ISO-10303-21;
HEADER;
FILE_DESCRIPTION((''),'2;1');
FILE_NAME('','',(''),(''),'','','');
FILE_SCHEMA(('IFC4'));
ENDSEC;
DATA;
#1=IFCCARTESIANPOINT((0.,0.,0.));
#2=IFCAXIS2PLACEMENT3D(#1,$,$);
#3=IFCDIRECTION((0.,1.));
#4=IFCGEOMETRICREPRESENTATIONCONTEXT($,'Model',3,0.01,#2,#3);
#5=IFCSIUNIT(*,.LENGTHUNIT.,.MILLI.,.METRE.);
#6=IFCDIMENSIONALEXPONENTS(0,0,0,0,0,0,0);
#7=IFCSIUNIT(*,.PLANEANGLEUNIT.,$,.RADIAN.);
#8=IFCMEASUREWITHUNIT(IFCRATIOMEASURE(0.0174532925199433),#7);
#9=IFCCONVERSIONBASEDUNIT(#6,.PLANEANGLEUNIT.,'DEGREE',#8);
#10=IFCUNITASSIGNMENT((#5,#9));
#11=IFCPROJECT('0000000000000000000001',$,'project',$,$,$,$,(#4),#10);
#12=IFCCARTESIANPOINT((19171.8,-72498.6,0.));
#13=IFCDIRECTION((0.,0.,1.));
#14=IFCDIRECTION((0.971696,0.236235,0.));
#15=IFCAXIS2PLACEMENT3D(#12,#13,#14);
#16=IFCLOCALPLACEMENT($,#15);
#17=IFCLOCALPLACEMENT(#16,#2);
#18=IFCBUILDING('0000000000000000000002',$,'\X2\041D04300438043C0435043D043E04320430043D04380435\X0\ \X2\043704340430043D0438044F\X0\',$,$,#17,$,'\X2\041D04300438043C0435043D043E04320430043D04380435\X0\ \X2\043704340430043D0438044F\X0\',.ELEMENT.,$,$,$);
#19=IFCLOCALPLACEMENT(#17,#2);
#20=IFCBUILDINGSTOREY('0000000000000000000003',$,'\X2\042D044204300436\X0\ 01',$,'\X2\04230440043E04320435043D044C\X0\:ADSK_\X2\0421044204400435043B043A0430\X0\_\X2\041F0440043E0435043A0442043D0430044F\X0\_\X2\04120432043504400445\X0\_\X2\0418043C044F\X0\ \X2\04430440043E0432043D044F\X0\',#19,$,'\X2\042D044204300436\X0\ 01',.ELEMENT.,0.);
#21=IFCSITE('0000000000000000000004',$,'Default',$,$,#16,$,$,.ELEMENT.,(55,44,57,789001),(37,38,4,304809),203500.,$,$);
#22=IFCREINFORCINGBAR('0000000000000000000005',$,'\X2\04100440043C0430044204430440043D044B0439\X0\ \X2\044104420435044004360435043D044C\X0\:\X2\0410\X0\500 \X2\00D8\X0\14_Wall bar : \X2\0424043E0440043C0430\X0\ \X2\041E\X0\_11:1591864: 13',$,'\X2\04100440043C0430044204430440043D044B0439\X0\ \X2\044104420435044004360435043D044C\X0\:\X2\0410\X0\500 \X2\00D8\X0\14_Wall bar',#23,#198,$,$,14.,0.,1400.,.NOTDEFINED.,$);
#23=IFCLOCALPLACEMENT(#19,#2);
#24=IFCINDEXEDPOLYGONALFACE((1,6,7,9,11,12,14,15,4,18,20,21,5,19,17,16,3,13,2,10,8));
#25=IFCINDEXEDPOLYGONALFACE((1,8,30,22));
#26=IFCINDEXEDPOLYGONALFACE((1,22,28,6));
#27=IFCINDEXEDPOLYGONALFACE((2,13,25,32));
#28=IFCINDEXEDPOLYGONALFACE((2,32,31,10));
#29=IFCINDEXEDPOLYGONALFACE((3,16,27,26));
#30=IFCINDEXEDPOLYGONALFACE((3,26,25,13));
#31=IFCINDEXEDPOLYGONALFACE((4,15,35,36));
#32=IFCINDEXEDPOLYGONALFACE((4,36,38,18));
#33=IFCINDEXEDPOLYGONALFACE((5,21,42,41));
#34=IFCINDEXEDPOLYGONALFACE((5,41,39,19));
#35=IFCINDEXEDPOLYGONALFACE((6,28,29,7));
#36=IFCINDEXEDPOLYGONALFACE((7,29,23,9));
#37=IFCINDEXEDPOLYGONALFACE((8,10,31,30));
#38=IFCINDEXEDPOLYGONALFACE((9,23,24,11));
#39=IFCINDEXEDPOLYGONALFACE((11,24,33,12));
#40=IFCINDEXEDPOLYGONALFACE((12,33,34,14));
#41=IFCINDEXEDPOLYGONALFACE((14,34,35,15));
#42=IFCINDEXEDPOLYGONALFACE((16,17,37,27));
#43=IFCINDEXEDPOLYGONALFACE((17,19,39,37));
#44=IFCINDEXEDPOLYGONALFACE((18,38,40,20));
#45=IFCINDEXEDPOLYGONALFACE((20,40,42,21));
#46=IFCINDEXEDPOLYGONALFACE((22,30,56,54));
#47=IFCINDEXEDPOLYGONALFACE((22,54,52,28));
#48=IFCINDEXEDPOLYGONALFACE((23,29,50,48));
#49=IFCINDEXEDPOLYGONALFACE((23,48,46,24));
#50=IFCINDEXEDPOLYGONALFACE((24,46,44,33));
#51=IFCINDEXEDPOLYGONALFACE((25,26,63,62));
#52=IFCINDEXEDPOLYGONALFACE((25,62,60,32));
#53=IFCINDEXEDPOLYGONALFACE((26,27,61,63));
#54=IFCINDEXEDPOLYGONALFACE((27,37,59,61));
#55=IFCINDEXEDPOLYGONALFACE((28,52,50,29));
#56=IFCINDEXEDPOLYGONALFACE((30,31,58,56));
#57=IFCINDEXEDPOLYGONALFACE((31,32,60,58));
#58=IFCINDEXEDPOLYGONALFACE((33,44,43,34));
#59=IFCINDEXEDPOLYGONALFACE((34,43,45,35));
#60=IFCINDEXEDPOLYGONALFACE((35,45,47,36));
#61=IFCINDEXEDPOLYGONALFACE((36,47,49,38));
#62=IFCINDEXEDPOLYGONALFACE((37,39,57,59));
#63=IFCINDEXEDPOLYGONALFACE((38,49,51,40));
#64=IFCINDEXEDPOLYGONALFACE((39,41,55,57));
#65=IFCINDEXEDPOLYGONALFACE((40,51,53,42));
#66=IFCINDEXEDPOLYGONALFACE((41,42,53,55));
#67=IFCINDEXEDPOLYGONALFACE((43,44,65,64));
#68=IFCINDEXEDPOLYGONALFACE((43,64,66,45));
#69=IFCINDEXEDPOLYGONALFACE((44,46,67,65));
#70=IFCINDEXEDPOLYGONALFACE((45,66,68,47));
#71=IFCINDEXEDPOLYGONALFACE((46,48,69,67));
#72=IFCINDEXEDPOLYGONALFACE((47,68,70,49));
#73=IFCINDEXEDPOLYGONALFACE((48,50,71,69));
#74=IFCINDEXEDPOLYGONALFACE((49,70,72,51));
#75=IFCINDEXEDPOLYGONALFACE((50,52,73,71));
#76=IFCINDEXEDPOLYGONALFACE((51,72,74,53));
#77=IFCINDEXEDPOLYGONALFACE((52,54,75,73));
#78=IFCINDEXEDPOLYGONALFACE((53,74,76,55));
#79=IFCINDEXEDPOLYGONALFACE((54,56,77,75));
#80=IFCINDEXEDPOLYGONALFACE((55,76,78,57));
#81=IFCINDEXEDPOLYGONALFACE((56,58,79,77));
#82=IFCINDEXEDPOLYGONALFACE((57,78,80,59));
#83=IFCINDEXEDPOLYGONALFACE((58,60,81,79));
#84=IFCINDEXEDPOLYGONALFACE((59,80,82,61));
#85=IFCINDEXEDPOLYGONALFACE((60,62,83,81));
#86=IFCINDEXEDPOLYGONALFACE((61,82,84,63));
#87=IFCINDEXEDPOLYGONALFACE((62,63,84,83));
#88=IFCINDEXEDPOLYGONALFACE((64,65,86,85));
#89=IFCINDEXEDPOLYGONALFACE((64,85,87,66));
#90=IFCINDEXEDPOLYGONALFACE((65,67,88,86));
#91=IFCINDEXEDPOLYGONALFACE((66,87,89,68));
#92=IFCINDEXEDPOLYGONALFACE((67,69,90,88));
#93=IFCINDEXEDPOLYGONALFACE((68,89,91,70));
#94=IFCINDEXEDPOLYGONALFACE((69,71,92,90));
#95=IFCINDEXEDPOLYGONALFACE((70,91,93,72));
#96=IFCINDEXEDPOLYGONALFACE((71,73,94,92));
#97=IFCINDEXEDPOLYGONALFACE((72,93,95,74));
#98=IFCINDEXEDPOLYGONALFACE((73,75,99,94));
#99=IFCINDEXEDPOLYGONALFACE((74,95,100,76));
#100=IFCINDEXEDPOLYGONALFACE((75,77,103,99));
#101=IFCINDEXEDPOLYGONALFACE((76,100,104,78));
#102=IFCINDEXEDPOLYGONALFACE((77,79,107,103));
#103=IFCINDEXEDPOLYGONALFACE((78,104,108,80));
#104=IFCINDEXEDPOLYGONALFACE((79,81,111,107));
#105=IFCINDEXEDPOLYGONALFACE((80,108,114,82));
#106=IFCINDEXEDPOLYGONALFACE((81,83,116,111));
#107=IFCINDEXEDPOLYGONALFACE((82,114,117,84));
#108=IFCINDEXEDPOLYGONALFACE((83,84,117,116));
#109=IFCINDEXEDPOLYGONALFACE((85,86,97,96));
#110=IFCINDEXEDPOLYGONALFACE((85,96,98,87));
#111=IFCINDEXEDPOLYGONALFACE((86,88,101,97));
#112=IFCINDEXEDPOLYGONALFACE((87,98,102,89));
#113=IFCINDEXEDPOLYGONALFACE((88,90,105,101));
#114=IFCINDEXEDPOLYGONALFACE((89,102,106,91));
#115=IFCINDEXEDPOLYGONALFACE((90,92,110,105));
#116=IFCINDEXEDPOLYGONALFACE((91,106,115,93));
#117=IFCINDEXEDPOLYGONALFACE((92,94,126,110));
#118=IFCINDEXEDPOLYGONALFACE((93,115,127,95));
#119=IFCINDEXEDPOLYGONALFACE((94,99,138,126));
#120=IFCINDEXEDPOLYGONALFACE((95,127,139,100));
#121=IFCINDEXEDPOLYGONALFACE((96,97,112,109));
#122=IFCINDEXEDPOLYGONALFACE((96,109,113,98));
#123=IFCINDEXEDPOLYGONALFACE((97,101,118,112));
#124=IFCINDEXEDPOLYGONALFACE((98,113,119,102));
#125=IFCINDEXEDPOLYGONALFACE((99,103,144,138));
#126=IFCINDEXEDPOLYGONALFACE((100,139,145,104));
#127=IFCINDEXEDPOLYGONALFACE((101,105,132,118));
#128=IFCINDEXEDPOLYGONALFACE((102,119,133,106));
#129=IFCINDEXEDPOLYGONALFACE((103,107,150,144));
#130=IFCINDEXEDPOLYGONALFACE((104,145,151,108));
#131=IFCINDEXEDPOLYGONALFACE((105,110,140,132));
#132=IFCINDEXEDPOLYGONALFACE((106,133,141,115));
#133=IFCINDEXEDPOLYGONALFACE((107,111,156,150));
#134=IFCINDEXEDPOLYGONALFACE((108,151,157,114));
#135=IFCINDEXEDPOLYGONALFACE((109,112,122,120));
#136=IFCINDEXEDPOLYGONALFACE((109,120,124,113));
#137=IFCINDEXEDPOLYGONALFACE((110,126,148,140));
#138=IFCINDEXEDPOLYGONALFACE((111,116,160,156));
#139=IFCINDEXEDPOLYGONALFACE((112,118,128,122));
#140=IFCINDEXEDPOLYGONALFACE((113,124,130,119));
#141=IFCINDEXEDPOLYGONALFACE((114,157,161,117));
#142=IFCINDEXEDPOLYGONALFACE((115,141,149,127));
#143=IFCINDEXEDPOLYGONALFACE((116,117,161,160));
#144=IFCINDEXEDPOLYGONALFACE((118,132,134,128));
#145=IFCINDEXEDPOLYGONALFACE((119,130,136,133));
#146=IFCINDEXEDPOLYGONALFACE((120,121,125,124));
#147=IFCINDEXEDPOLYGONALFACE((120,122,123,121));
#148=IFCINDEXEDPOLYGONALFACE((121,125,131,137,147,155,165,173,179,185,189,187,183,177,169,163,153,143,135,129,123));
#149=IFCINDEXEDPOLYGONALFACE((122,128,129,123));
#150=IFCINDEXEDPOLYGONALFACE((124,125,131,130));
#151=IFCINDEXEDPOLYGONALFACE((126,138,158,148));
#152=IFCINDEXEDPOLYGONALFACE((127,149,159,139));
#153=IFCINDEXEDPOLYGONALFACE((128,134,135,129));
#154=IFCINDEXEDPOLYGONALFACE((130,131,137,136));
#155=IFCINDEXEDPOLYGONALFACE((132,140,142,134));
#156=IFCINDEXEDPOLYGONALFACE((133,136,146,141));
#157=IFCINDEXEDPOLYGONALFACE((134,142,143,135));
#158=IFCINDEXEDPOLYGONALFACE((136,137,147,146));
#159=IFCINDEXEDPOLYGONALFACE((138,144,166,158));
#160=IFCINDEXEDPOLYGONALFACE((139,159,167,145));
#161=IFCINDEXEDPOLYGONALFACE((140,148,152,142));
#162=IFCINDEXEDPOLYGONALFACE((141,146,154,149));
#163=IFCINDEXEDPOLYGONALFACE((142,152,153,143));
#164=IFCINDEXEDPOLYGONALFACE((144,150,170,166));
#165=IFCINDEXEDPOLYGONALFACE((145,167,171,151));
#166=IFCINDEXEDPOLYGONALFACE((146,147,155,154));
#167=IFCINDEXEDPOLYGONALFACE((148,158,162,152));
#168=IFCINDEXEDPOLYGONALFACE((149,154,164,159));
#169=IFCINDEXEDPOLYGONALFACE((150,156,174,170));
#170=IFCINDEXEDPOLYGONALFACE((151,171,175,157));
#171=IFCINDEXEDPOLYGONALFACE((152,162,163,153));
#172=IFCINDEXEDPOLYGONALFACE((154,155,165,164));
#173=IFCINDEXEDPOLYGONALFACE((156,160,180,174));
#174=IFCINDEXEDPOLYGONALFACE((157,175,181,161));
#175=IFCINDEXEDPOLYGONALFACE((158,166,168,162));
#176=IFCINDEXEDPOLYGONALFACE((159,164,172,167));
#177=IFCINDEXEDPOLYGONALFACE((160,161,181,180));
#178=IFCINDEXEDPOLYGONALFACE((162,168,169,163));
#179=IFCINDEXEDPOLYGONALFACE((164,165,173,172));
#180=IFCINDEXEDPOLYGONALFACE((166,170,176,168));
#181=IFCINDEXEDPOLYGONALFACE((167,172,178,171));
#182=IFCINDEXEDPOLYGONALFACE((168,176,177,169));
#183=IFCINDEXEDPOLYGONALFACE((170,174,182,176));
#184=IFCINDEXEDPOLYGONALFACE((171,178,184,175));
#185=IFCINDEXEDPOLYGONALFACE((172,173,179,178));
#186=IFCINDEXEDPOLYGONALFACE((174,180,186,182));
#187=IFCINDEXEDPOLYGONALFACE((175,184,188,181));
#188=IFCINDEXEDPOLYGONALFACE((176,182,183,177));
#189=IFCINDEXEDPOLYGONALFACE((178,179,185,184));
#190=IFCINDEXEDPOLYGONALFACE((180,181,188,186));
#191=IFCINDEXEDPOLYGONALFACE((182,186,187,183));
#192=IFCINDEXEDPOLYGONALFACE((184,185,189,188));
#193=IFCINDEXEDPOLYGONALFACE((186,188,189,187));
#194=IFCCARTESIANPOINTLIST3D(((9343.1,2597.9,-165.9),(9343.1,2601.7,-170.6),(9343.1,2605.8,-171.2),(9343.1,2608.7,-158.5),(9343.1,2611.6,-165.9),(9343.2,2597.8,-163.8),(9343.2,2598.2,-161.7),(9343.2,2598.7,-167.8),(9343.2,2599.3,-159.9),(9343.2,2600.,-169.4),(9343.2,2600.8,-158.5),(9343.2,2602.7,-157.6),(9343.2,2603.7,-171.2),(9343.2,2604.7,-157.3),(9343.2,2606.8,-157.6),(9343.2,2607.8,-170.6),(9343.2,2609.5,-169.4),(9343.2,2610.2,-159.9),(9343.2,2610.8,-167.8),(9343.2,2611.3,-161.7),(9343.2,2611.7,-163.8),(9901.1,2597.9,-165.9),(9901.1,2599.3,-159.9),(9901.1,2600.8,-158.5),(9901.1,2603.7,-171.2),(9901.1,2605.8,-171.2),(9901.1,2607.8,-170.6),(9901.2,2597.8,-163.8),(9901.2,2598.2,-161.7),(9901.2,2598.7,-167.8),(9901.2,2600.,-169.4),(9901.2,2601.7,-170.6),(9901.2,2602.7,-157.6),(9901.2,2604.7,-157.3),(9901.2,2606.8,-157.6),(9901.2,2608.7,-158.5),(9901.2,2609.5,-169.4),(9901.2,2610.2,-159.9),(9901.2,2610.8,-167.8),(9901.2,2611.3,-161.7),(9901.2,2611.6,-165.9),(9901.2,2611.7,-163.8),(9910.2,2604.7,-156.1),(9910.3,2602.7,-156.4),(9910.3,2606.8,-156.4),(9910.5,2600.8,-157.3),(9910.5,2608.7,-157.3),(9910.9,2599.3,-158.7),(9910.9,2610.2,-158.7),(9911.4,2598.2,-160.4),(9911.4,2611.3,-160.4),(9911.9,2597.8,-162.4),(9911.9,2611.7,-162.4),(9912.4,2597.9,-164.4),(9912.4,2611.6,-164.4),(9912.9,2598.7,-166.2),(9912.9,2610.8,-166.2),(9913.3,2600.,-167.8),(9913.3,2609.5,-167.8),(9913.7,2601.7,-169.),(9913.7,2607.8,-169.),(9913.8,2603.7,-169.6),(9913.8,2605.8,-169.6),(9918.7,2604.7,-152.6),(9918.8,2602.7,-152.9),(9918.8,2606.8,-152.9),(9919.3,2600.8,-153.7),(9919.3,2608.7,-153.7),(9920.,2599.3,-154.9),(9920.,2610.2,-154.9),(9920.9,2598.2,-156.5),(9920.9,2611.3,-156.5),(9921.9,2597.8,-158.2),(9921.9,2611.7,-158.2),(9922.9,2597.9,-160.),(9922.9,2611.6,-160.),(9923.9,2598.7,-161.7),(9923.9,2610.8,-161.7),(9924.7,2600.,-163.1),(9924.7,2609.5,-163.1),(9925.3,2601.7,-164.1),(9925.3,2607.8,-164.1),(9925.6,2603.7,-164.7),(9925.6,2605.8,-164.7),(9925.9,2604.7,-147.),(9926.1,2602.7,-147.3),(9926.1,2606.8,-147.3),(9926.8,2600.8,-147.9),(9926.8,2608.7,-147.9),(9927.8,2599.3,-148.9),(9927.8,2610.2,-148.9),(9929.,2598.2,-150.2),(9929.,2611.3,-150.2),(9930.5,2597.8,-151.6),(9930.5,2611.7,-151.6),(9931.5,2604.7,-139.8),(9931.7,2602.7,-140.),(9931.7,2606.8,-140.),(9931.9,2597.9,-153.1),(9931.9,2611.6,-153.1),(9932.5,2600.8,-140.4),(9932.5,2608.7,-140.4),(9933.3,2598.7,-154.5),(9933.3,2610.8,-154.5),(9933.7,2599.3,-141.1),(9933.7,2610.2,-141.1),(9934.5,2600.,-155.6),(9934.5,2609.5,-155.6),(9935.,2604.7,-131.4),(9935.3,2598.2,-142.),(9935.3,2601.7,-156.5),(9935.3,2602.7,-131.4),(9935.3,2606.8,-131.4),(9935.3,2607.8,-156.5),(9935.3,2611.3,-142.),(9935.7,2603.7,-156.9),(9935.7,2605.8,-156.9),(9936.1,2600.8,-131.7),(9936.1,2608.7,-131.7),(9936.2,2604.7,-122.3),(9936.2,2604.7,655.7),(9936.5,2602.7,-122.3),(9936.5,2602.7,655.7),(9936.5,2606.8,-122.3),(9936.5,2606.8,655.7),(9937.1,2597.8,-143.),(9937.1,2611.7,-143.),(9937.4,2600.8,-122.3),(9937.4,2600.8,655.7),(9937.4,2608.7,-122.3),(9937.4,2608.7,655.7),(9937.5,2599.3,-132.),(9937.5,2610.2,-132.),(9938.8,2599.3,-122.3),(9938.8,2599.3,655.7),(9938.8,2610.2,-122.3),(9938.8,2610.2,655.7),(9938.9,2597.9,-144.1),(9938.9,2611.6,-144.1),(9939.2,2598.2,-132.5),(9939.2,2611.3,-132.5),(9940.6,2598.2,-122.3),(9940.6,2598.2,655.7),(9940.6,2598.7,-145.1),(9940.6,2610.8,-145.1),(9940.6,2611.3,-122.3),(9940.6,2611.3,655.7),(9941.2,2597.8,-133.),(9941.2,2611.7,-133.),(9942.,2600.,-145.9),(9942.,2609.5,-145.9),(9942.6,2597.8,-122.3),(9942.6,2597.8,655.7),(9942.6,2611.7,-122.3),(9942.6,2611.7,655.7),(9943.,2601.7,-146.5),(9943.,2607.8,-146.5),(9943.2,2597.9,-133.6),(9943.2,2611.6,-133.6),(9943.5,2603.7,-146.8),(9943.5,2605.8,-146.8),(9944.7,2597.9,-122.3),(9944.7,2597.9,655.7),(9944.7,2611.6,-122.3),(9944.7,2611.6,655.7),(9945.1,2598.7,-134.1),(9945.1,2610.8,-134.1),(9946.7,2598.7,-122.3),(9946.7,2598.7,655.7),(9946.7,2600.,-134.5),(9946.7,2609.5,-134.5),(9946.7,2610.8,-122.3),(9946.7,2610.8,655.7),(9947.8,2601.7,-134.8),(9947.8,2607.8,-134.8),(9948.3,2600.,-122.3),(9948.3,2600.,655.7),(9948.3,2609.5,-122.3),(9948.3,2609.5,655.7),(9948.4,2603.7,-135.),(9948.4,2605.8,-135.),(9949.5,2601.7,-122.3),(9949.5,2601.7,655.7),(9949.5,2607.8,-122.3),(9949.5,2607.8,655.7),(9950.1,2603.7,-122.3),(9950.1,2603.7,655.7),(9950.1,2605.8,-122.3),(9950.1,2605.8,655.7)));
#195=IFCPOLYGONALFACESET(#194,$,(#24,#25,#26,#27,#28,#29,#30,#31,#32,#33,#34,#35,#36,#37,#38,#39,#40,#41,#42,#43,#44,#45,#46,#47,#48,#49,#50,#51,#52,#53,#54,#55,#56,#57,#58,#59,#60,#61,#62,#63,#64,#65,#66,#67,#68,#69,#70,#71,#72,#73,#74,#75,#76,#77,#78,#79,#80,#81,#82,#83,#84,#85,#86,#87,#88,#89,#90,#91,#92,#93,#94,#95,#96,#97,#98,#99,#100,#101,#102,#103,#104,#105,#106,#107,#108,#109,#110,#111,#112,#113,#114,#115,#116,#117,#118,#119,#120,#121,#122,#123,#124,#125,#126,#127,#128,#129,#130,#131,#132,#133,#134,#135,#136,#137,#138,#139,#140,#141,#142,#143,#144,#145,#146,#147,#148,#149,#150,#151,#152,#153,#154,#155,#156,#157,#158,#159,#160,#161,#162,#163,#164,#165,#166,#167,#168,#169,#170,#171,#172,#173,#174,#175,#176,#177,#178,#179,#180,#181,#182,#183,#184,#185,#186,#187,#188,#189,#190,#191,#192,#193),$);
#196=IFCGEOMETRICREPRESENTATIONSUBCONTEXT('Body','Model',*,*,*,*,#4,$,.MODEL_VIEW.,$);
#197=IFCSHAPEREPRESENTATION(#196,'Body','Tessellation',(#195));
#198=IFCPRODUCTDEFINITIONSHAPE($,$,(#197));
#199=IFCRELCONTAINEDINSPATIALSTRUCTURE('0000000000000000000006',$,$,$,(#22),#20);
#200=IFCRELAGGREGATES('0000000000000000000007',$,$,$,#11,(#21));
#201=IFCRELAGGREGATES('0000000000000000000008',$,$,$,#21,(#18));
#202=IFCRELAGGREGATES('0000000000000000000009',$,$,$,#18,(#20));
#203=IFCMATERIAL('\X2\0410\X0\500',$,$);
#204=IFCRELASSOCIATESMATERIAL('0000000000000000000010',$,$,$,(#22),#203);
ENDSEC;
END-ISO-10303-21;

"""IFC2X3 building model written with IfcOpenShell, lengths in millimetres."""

from ifc_helpers import new_model, entity, si_unit, converted_unit, direction, frame, origin, place, context, subcontext, project, spatial, material, element, save


model = new_model("IFC2X3")

# Units and contexts
model_context = context("Model", 3, precision=0.01, world=origin(), true_north=direction((0.0, 1.0)))
body_context = subcontext(model_context, "Body", "Model", "MODEL_VIEW")
ifc_project = project(units=[si_unit("LENGTHUNIT", "METRE", prefix="MILLI"), converted_unit("PLANEANGLEUNIT", "DEGREE", entity("IfcRatioMeasure", 0.0174532925199433), si_unit("PLANEANGLEUNIT", "RADIAN"), dimensions=[0, 0, 0, 0, 0, 0, 0])], contexts=[model_context])

# Site, building, storey
site_placement = place(None, frame((19171.8, -72498.6, 0.0), z_axis=(0.0, 0.0, 1.0), x_axis=(0.971696, 0.236235, 0.0)))
site = spatial("IfcSite", under=ifc_project, at=site_placement, Name="Default", CompositionType="ELEMENT", RefLatitude=(55, 44, 57, 789001), RefLongitude=(37, 38, 4, 304809), RefElevation=203500.0)
building_placement = place(site_placement, origin())
building = spatial("IfcBuilding", under=site, at=building_placement, Name="Наименование здания", LongName="Наименование здания", CompositionType="ELEMENT")
storey_placement = place(building_placement, origin())
storey = spatial("IfcBuildingStorey", under=building, at=storey_placement, Name="Этаж 01", ObjectType="Уровень:ADSK_Стрелка_Проектная_Вверх_Имя уровня", LongName="Этаж 01", CompositionType="ELEMENT", Elevation=0.0)

# Reinforcing bar
ifc_material = material(Name="А500")
placement = place(storey_placement, origin())
element("IfcReinforcingBar", 1, at=placement, inside=storey, material=ifc_material, Name="Арматурный стержень:А500 Ø14_Wall bar : Форма О_11:1591864: 13", ObjectType="Арматурный стержень:А500 Ø14_Wall bar", BarLength=1400.0, BarRole="NOTDEFINED", CrossSectionArea=0.0, NominalDiameter=14.0, context=body_context, shape_type="AdvancedSweptSolid", body=[
    entity("IfcSweptDiskSolid", entity("IfcCompositeCurve", [entity("IfcCompositeCurveSegment", "CONTINUOUS", True, entity("IfcPolyline", [entity("IfcCartesianPoint", [9943.1, 2604.7, 655.7]), entity("IfcCartesianPoint", [9943.1, 2604.7, -122.3])])), entity("IfcCompositeCurveSegment", "CONTINUOUS", True, entity("IfcTrimmedCurve", entity("IfcCircle", entity("IfcAxis2Placement3D", entity("IfcCartesianPoint", [9901.1, 2604.7, -122.3]), entity("IfcDirection", [0.0, 1.0, 0.0]), entity("IfcDirection", [0.0, 0.0, -1.0])), 42.0), [entity("IfcParameterValue", 270.0)], [entity("IfcParameterValue", 360.0)], True, "PARAMETER")), entity("IfcCompositeCurveSegment", "CONTINUOUS", True, entity("IfcPolyline", [entity("IfcCartesianPoint", [9901.1, 2604.7, -164.3]), entity("IfcCartesianPoint", [9343.1, 2604.7, -164.3])]))], False), 7.0, None, 0.0, 92.0),
])

save(model, "model.ifc")
